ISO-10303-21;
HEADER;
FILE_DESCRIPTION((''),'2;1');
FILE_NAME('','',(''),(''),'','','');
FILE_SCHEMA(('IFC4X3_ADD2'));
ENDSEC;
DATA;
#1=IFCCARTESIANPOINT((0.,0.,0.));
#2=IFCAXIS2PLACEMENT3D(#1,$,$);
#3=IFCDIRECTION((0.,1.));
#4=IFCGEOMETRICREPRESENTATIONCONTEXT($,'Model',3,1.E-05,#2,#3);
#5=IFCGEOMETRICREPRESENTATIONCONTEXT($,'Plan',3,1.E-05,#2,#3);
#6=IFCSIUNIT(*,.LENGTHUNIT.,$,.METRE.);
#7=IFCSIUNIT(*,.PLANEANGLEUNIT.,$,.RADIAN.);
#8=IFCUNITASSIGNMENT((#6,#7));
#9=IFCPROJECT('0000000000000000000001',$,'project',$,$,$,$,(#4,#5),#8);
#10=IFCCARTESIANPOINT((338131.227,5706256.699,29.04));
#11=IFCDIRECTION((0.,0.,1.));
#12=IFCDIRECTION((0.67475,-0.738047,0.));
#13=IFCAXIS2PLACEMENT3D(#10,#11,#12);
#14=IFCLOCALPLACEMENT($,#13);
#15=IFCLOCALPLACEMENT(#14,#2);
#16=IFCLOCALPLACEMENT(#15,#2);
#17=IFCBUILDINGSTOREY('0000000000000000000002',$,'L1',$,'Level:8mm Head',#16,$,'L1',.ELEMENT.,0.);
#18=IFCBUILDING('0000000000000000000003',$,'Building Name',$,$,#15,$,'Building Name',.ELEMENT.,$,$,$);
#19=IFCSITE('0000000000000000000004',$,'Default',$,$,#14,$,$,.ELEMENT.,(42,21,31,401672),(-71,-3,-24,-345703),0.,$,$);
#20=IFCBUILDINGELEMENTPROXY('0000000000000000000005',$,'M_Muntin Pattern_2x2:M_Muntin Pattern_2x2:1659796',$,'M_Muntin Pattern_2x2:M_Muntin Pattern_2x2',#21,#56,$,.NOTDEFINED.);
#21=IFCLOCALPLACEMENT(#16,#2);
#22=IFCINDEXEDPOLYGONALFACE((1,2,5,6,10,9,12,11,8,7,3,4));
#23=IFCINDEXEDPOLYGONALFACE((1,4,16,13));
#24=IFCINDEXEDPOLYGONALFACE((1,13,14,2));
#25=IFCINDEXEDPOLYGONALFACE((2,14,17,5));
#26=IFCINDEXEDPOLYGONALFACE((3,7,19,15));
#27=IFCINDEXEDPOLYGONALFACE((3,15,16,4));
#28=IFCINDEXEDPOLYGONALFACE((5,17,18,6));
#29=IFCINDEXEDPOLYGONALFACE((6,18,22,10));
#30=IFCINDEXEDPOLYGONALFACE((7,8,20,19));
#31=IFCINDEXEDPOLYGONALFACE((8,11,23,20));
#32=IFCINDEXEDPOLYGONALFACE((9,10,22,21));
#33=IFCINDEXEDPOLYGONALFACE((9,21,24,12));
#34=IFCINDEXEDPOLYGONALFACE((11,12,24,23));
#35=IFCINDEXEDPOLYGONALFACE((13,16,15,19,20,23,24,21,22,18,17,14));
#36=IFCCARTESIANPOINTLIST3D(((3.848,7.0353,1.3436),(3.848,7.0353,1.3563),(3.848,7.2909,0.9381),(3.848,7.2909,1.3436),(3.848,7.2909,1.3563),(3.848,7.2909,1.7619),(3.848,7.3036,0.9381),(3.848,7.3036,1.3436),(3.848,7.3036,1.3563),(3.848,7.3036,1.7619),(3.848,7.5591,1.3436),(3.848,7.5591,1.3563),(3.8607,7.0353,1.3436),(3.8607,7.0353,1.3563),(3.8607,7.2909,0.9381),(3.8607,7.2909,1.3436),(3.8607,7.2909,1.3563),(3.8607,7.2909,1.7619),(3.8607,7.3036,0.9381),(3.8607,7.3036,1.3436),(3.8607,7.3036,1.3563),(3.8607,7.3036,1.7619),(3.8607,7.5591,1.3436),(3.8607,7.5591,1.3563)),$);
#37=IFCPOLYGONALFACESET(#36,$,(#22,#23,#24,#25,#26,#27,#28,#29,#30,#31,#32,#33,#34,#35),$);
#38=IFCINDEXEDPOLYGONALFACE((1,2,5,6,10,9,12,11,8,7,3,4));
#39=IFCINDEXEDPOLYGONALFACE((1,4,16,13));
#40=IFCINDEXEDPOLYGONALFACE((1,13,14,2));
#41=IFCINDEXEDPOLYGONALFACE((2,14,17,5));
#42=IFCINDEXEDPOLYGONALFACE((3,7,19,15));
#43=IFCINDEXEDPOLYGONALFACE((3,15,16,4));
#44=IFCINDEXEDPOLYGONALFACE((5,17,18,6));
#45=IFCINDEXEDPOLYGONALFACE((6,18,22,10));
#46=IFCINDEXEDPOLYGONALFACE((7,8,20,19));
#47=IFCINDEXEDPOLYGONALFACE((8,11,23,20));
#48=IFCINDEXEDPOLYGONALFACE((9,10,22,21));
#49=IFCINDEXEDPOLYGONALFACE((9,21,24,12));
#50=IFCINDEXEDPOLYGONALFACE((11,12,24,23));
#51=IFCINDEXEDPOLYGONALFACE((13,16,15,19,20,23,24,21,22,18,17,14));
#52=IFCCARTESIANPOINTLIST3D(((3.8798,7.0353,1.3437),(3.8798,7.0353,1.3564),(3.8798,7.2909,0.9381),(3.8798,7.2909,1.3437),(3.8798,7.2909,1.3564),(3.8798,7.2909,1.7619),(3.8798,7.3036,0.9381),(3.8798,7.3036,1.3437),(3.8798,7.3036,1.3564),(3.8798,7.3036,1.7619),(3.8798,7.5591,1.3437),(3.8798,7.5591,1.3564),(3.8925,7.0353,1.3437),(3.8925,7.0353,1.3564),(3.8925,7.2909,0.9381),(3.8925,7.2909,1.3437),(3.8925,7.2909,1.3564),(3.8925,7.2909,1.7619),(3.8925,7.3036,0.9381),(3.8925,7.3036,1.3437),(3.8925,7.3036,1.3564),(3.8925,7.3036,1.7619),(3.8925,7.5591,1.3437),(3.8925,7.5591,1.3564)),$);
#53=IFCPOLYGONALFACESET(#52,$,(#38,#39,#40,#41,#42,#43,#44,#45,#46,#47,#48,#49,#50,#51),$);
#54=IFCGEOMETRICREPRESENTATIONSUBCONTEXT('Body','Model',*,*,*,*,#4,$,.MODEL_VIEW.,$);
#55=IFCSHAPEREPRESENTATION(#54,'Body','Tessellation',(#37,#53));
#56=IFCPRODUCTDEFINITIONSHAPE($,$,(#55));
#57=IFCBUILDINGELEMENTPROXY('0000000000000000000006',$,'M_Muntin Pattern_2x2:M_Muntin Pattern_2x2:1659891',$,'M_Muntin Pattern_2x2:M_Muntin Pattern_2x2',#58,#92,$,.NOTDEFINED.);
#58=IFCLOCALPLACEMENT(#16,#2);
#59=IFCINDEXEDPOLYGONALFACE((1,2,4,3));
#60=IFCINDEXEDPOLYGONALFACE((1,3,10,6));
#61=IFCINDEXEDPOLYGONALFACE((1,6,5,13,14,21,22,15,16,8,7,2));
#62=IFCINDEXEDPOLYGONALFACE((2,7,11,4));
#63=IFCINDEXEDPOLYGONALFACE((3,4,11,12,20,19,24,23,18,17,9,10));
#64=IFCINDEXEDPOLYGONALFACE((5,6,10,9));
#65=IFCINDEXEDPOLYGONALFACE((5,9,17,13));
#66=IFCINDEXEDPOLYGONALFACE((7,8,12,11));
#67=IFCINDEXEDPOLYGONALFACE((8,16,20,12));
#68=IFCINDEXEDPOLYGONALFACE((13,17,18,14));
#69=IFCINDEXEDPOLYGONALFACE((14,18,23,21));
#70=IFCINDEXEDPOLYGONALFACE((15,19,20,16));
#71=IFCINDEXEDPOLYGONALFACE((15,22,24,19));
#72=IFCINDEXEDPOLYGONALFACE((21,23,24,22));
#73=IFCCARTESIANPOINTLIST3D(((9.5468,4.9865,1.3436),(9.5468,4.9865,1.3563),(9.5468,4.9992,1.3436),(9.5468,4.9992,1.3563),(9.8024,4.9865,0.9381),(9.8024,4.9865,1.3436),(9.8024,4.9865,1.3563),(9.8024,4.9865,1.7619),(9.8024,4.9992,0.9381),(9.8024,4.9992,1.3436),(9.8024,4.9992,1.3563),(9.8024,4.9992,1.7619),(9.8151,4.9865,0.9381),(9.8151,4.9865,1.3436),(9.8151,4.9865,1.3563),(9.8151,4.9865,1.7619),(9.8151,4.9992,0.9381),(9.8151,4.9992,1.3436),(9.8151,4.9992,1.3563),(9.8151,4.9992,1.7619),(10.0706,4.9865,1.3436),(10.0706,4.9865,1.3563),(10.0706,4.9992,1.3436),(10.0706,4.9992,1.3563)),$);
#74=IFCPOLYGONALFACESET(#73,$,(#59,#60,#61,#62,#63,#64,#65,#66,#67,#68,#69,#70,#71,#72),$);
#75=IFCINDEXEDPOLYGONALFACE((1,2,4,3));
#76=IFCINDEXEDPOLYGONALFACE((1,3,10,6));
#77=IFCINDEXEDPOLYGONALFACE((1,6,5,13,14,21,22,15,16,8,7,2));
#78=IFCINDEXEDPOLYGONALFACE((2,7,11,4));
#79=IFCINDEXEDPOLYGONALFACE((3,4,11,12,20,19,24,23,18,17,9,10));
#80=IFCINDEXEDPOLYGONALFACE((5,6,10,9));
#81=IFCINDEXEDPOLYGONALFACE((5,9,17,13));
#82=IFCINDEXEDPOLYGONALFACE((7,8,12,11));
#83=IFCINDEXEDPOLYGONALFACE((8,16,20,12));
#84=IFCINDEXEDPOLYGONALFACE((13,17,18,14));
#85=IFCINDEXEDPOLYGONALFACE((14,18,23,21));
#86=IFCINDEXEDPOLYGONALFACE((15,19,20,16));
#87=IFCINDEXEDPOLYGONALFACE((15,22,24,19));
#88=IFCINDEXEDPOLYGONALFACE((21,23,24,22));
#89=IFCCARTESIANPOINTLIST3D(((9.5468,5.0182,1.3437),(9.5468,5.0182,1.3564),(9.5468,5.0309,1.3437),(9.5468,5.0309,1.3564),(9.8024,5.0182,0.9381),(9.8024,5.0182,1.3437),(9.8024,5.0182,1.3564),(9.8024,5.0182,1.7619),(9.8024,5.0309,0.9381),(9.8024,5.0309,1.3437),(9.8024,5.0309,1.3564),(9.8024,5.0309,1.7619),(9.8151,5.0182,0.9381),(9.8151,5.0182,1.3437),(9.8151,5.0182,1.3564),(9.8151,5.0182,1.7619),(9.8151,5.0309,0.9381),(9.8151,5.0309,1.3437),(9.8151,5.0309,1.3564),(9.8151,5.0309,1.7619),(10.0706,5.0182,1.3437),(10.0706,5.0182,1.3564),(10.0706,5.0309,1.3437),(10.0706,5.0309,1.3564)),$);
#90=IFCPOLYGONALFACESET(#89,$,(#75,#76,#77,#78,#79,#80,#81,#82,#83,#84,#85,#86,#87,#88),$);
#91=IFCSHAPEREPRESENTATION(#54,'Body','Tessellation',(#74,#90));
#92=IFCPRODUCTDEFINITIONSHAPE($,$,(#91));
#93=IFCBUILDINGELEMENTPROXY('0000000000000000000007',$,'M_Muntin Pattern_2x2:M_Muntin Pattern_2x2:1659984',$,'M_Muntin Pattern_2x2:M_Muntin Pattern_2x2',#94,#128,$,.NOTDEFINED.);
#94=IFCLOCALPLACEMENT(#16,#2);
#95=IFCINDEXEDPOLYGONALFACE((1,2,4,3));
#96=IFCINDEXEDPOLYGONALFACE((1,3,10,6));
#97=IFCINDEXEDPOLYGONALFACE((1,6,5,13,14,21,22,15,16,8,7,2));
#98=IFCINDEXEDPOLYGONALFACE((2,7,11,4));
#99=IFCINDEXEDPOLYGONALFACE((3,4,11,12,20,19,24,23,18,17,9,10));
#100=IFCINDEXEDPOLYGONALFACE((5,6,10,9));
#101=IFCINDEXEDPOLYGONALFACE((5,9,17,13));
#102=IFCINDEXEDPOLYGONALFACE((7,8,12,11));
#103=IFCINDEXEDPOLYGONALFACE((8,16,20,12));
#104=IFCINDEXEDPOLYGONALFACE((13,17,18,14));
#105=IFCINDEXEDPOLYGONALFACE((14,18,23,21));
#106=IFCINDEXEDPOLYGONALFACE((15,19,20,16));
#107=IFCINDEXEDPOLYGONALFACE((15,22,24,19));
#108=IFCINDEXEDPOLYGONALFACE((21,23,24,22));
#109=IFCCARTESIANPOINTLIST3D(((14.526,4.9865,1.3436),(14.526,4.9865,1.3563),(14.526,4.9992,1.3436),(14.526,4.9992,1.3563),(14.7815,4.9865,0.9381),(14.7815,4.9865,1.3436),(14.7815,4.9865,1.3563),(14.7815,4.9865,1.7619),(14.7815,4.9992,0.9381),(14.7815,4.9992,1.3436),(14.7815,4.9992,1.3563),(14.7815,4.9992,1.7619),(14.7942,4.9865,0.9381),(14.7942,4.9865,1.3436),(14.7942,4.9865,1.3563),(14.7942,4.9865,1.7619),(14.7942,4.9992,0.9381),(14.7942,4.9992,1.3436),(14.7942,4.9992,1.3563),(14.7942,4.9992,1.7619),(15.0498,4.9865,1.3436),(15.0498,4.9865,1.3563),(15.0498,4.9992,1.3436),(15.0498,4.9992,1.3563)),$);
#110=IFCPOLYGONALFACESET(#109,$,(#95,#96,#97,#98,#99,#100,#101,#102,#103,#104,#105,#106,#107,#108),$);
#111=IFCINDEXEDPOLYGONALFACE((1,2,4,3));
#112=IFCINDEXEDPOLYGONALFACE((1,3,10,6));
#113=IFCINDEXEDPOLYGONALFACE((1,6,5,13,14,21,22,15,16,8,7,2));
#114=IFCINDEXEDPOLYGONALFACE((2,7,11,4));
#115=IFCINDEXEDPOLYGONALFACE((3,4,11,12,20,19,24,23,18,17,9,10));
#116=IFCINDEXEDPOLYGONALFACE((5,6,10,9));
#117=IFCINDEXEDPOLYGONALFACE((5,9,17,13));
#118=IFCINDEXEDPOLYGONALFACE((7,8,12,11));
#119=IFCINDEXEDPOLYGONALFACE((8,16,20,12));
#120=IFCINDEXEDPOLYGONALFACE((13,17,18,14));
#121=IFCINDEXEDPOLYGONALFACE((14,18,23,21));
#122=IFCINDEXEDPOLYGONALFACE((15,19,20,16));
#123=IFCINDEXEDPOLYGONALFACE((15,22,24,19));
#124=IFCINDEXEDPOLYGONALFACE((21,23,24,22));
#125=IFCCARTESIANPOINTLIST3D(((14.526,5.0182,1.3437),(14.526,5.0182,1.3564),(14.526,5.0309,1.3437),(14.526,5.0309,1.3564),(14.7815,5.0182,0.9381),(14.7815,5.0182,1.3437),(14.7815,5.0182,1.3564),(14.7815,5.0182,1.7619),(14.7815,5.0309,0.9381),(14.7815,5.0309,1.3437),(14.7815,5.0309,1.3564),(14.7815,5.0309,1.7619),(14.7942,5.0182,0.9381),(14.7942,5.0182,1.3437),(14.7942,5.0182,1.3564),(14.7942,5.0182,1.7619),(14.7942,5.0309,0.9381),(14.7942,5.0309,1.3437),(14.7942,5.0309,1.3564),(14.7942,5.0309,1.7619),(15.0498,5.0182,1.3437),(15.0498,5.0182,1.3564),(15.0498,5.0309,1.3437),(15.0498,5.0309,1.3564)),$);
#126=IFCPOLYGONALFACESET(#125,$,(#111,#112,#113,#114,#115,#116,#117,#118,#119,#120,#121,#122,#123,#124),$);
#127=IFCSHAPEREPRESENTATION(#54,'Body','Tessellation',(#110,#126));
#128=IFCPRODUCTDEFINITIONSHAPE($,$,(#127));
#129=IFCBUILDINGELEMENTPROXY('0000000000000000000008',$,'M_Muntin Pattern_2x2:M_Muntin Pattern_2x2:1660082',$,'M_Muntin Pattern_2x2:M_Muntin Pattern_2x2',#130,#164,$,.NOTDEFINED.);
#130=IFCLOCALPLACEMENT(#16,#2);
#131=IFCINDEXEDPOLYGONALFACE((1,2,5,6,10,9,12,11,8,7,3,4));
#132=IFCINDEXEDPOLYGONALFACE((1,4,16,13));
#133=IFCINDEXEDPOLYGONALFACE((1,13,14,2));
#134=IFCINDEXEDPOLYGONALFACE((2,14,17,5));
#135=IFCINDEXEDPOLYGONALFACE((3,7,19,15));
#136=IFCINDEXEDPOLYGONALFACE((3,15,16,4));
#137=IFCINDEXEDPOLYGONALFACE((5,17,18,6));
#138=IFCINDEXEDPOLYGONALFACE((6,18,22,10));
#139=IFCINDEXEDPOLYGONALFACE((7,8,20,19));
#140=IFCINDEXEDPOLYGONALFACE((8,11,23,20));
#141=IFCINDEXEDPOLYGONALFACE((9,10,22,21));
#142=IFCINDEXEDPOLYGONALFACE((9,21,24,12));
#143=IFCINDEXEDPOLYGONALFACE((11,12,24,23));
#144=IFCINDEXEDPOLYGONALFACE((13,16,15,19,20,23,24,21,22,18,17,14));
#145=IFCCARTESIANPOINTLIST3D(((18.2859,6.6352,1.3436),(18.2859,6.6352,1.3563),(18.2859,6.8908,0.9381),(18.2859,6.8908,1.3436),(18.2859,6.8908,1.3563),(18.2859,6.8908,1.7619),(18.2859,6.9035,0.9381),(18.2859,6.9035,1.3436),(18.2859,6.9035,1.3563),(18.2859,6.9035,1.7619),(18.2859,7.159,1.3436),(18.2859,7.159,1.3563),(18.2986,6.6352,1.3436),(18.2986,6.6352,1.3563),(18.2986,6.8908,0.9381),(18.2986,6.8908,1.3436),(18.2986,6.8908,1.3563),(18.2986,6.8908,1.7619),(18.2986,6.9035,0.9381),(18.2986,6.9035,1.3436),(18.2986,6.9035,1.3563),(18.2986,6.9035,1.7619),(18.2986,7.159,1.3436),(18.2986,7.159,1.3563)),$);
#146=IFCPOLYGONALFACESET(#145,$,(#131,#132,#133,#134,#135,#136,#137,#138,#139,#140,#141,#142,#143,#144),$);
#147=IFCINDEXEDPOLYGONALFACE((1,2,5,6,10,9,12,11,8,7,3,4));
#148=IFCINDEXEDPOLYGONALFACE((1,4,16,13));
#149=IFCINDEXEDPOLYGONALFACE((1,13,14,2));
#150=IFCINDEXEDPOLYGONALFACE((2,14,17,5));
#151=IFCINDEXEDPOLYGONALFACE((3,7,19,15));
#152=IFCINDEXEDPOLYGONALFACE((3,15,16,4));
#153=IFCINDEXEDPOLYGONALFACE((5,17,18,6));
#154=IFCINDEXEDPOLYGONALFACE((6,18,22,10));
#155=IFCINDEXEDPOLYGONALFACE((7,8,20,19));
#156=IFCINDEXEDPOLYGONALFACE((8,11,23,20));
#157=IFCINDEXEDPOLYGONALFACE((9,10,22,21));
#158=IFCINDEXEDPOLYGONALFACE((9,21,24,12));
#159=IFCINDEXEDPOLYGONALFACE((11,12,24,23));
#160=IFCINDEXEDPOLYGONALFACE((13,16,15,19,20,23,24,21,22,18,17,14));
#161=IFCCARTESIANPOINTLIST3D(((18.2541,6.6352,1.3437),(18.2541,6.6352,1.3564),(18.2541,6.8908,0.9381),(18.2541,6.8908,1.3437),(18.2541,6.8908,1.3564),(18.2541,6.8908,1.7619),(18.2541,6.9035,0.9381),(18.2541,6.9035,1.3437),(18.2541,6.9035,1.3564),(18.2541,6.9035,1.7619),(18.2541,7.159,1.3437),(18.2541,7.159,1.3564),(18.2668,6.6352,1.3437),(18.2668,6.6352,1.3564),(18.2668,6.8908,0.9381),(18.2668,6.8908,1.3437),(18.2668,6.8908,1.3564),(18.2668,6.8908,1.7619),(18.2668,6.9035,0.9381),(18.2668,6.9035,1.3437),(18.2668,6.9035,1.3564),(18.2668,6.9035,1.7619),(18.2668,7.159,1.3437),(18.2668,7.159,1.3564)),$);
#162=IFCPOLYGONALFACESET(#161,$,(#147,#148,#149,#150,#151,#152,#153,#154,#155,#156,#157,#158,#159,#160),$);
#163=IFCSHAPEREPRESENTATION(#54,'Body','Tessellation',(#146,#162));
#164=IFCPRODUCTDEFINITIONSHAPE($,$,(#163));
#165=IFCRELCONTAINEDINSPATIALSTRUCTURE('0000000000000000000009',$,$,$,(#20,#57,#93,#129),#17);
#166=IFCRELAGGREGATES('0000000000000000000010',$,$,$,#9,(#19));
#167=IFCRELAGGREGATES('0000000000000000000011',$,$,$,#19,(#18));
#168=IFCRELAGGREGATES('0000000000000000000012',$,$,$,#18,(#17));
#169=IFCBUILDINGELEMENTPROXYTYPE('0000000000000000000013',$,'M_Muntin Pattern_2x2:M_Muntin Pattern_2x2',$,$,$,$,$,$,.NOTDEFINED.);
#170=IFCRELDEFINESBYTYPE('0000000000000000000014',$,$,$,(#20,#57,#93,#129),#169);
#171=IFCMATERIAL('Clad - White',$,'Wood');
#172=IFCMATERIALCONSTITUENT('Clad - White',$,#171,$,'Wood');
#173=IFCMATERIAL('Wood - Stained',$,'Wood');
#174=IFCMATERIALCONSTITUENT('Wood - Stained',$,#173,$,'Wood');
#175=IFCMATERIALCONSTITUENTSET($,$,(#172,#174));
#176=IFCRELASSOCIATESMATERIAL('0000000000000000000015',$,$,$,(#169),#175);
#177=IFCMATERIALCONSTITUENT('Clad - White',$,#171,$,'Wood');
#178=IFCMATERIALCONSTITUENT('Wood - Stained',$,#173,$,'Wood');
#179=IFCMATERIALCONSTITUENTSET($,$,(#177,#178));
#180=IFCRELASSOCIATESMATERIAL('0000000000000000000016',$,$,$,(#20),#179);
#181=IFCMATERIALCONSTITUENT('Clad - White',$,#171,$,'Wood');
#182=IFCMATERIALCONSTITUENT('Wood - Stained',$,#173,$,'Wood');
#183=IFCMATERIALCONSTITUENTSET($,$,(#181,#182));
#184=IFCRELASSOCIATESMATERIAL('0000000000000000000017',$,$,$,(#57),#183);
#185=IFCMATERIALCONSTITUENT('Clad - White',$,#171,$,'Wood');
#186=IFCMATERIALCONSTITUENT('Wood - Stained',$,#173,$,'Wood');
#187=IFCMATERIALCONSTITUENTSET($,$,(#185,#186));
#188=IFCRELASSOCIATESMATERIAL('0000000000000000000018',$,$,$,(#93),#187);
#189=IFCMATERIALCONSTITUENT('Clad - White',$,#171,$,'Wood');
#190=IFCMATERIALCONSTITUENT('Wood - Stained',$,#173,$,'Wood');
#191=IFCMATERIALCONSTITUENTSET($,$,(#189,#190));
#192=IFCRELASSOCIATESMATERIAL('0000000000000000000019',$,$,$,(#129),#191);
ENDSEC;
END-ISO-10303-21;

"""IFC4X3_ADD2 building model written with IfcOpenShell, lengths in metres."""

from ifc_helpers import new_model, si_unit, direction, frame, origin, place, context, subcontext, project, spatial, polyline, outline, extrude, source, transform, mapped, material, constituent, constituent_set, type_object, type_shapes, element, save


model = new_model("IFC4X3_ADD2")

# Units and contexts
model_context = context("Model", 3, precision=1e-05, world=origin(), true_north=direction((0.0, 1.0)))
plan_context = context("Plan", 3, precision=1e-05, world=origin(), true_north=direction((0.0, 1.0)))
body_context = subcontext(model_context, "Body", "Model", "MODEL_VIEW")
ifc_project = project(units=[si_unit("LENGTHUNIT", "METRE"), si_unit("PLANEANGLEUNIT", "RADIAN")], contexts=[model_context, plan_context])

# Site, building, storey
site_placement = place(None, frame((338131.227, 5706256.699, 29.04), z_axis=(0.0, 0.0, 1.0), x_axis=(0.67475, -0.738047, 0.0)))
site = spatial("IfcSite", under=ifc_project, at=site_placement, Name="Default", CompositionType="ELEMENT", RefLatitude=(42, 21, 31, 401672), RefLongitude=(-71, -3, -24, -345703), RefElevation=0.0)
building_placement = place(site_placement, origin())
building = spatial("IfcBuilding", under=site, at=building_placement, Name="Building Name", LongName="Building Name", CompositionType="ELEMENT")
storey_placement = place(building_placement, origin())
storey = spatial("IfcBuildingStorey", under=building, at=storey_placement, Name="L1", ObjectType="Level:8mm Head", LongName="L1", CompositionType="ELEMENT", Elevation=0.0)

# Building element proxies
ifc_material_1 = material(Name="Clad - White", Category="Wood")
ifc_material_2 = material(Name="Wood - Stained", Category="Wood")
ifc_constituent_1 = constituent(ifc_material_1, Name="Clad - White", Category="Wood")
ifc_constituent_2 = constituent(ifc_material_2, Name="Wood - Stained", Category="Wood")
ifc_constituent_set_1 = constituent_set(constituents=[ifc_constituent_1, ifc_constituent_2])
building_element_proxy_type = type_object("IfcBuildingElementProxyType", Name="M_Muntin Pattern_2x2:M_Muntin Pattern_2x2", PredefinedType="NOTDEFINED", material=ifc_constituent_set_1)
shared_shape = source(origin(), body_context, "Body", "SweptSolid", [
    extrude(outline(polyline([(0.0064, -0.0064), (0.4119, -0.0064), (0.4119, 0.0063), (0.0064, 0.0063), (0.0064, 0.2619), (-0.0063, 0.2619), (-0.0063, 0.0063), (-0.4119, 0.0063), (-0.4119, -0.0064), (-0.0063, -0.0064), (-0.0063, -0.2619), (0.0064, -0.2619), (0.0064, -0.0064)])), frame((0.0, -0.0222, 0.4119), z_axis=(0.0, 1.0, 0.0), x_axis=(0.0, 0.0, 1.0)), (0.0, 0.0, 1.0), 0.0127),
    extrude(outline(polyline([(0.0064, -0.0064), (0.4119, -0.0064), (0.4119, 0.0063), (0.0064, 0.0063), (0.0064, 0.2619), (-0.0063, 0.2619), (-0.0063, 0.0063), (-0.4119, 0.0063), (-0.4119, -0.0064), (-0.0063, -0.0064), (-0.0063, -0.2619), (0.0064, -0.2619), (0.0064, -0.0064)])), frame((0.0, 0.0095, 0.4119), z_axis=(0.0, 1.0, 0.0), x_axis=(0.0, 0.0, 1.0)), (0.0, 0.0, 1.0), 0.0127),
])
type_shapes(building_element_proxy_type, [shared_shape])
ifc_constituent_3 = constituent(ifc_material_1, Name="Clad - White", Category="Wood")
ifc_constituent_4 = constituent(ifc_material_2, Name="Wood - Stained", Category="Wood")
ifc_constituent_set_2 = constituent_set(constituents=[ifc_constituent_3, ifc_constituent_4])
proxy_1_placement = place(storey_placement, frame((3.8703, 7.2972, 0.9381), z_axis=(0.0, 0.0, 1.0), x_axis=(0.0, -1.0, 0.0)))
element("IfcBuildingElementProxy", 1, at=proxy_1_placement, inside=storey, type_object=building_element_proxy_type, material=ifc_constituent_set_2, Name="M_Muntin Pattern_2x2:M_Muntin Pattern_2x2:1659796", ObjectType="M_Muntin Pattern_2x2:M_Muntin Pattern_2x2", PredefinedType="NOTDEFINED", context=body_context, shape_type="MappedRepresentation", body=[
    mapped(shared_shape, transform((0.0, 0.0, 0.0), scale=1.0)),
])
ifc_constituent_5 = constituent(ifc_material_1, Name="Clad - White", Category="Wood")
ifc_constituent_6 = constituent(ifc_material_2, Name="Wood - Stained", Category="Wood")
ifc_constituent_set_3 = constituent_set(constituents=[ifc_constituent_5, ifc_constituent_6])
proxy_2_placement = place(storey_placement, frame((9.8087, 5.0087, 0.9381)))
element("IfcBuildingElementProxy", 2, at=proxy_2_placement, inside=storey, type_object=building_element_proxy_type, material=ifc_constituent_set_3, Name="M_Muntin Pattern_2x2:M_Muntin Pattern_2x2:1659891", ObjectType="M_Muntin Pattern_2x2:M_Muntin Pattern_2x2", PredefinedType="NOTDEFINED", context=body_context, shape_type="MappedRepresentation", body=[
    mapped(shared_shape, transform((0.0, 0.0, 0.0), scale=1.0)),
])
ifc_constituent_7 = constituent(ifc_material_1, Name="Clad - White", Category="Wood")
ifc_constituent_8 = constituent(ifc_material_2, Name="Wood - Stained", Category="Wood")
ifc_constituent_set_4 = constituent_set(constituents=[ifc_constituent_7, ifc_constituent_8])
proxy_3_placement = place(storey_placement, frame((14.7879, 5.0087, 0.9381)))
element("IfcBuildingElementProxy", 3, at=proxy_3_placement, inside=storey, type_object=building_element_proxy_type, material=ifc_constituent_set_4, Name="M_Muntin Pattern_2x2:M_Muntin Pattern_2x2:1659984", ObjectType="M_Muntin Pattern_2x2:M_Muntin Pattern_2x2", PredefinedType="NOTDEFINED", context=body_context, shape_type="MappedRepresentation", body=[
    mapped(shared_shape, transform((0.0, 0.0, 0.0), scale=1.0)),
])
ifc_constituent_9 = constituent(ifc_material_1, Name="Clad - White", Category="Wood")
ifc_constituent_10 = constituent(ifc_material_2, Name="Wood - Stained", Category="Wood")
ifc_constituent_set_5 = constituent_set(constituents=[ifc_constituent_9, ifc_constituent_10])
proxy_4_placement = place(storey_placement, frame((18.2763, 6.8971, 0.9381), z_axis=(0.0, 0.0, 1.0), x_axis=(0.0, 1.0, 0.0)))
element("IfcBuildingElementProxy", 4, at=proxy_4_placement, inside=storey, type_object=building_element_proxy_type, material=ifc_constituent_set_5, Name="M_Muntin Pattern_2x2:M_Muntin Pattern_2x2:1660082", ObjectType="M_Muntin Pattern_2x2:M_Muntin Pattern_2x2", PredefinedType="NOTDEFINED", context=body_context, shape_type="MappedRepresentation", body=[
    mapped(shared_shape, transform((0.0, 0.0, 0.0), scale=1.0)),
])

save(model, "model.ifc")
